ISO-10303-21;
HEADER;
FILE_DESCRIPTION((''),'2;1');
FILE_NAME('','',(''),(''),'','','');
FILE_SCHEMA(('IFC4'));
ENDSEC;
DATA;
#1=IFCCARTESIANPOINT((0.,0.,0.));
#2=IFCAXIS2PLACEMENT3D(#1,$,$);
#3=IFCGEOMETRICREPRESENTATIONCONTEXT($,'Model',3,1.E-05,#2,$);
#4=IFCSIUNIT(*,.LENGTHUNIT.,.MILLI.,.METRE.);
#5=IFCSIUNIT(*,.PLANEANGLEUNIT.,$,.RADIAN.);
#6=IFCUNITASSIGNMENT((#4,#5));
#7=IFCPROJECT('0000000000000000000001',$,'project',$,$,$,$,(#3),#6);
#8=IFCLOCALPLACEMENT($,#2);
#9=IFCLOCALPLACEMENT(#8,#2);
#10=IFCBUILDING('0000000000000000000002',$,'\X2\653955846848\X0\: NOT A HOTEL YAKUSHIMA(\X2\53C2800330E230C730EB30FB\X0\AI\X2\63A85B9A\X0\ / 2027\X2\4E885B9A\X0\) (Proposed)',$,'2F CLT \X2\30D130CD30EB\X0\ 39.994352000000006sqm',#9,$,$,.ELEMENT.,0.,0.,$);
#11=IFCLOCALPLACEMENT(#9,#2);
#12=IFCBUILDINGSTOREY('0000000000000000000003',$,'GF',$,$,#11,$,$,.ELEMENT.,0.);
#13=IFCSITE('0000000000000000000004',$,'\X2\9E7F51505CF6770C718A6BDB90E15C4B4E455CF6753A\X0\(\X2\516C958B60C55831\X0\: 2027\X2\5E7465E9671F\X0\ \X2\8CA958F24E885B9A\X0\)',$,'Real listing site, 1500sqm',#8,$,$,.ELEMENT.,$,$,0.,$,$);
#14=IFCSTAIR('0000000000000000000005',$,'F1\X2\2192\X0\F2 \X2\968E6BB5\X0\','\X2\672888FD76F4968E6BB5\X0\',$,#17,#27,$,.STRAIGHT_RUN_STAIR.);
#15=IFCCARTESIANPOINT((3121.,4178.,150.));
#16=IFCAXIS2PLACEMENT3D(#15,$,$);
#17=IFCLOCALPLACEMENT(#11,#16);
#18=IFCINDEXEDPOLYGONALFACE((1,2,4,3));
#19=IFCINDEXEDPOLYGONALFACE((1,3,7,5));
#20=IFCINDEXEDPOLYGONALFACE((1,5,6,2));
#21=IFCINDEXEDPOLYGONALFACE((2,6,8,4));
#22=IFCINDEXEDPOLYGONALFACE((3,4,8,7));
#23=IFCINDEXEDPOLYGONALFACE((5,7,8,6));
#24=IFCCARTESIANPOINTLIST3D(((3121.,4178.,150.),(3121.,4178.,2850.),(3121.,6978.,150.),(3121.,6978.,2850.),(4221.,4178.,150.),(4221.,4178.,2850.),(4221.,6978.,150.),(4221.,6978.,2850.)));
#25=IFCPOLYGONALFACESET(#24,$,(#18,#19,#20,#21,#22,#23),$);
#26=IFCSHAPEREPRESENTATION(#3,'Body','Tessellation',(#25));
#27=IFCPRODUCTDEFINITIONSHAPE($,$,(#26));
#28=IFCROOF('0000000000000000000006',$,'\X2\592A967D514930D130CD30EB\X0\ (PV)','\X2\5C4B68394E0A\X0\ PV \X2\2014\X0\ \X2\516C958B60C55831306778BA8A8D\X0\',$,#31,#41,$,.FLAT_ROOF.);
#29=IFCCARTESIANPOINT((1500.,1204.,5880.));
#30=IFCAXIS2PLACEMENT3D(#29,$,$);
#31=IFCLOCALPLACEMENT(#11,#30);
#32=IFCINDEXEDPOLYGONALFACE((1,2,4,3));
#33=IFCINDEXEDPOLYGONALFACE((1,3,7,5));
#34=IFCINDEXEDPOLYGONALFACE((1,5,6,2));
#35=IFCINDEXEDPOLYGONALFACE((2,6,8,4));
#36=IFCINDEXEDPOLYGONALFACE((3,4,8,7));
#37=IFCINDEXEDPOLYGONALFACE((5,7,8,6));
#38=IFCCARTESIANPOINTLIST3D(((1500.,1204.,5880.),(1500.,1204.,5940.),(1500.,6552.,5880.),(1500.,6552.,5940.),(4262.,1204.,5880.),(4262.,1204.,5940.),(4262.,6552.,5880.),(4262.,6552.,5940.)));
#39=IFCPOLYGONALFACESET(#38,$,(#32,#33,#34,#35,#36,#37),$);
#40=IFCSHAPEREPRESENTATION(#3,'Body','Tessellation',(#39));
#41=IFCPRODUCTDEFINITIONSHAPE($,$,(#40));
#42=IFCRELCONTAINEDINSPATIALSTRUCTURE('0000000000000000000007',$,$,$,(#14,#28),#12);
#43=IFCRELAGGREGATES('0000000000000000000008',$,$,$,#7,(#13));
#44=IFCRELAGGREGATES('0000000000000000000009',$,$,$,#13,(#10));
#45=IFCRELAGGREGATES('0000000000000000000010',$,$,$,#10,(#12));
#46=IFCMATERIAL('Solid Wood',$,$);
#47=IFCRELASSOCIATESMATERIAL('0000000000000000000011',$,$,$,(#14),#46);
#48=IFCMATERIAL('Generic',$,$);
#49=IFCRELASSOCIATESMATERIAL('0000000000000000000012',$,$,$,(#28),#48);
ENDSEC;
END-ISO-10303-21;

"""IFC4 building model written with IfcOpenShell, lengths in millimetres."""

from ifc_helpers import new_model, si_unit, frame, frame_2d, origin, place, context, project, spatial, rectangle, extrude, material, element, save


model = new_model("IFC4")

# Units and contexts
model_context = context("Model", 3, precision=1e-05, world=origin())
ifc_project = project(units=[si_unit("LENGTHUNIT", "METRE", prefix="MILLI"), si_unit("PLANEANGLEUNIT", "RADIAN")], contexts=[model_context])

# Site, building, storey
site_placement = place(None, origin())
site = spatial("IfcSite", under=ifc_project, at=site_placement, Name="鹿児島県熊毛郡屋久島町(公開情報: 2027年早期 販売予定)", ObjectType="Real listing site, 1500sqm", CompositionType="ELEMENT", RefElevation=0.0)
building_placement = place(site_placement, origin())
building = spatial("IfcBuilding", under=site, at=building_placement, Name="改善案: NOT A HOTEL YAKUSHIMA(参考モデル・AI推定 / 2027予定) (Proposed)", ObjectType="2F CLT パネル 39.994352000000006sqm", CompositionType="ELEMENT", ElevationOfRefHeight=0.0, ElevationOfTerrain=0.0)
storey_placement = place(building_placement, origin())
storey = spatial("IfcBuildingStorey", under=building, at=storey_placement, Name="GF", CompositionType="ELEMENT", Elevation=0.0)

# Shared definitions
ifc_material_1 = material(Name="Generic")

# Stair
ifc_material_2 = material(Name="Solid Wood")
stair_placement = place(storey_placement, frame((3121.0, 4178.0, 150.0)))
element("IfcStair", 1, at=stair_placement, inside=storey, material=ifc_material_2, Name="F1→F2 階段", Description="木製直階段", PredefinedType="STRAIGHT_RUN_STAIR", context=model_context, shape_type="SweptSolid", body=[
    extrude(rectangle(XDim=1100.0, YDim=2800.0, at=frame_2d((550.0, 1400.0))), frame((3121.0, 4178.0, 150.0)), (0.0, 0.0, 1.0), 2700.0),
])

# Roof
roof_placement = place(storey_placement, frame((1500.0, 1204.0, 5880.0)))
element("IfcRoof", 2, at=roof_placement, inside=storey, material=ifc_material_1, Name="太陽光パネル (PV)", Description="屋根上 PV — 公開情報で確認", PredefinedType="FLAT_ROOF", context=model_context, shape_type="SweptSolid", body=[
    extrude(rectangle(XDim=2762.0, YDim=5348.0, at=frame_2d((1381.0, 2674.0))), frame((1500.0, 1204.0, 5880.0)), (0.0, 0.0, 1.0), 60.0),
])

save(model, "model.ifc")
